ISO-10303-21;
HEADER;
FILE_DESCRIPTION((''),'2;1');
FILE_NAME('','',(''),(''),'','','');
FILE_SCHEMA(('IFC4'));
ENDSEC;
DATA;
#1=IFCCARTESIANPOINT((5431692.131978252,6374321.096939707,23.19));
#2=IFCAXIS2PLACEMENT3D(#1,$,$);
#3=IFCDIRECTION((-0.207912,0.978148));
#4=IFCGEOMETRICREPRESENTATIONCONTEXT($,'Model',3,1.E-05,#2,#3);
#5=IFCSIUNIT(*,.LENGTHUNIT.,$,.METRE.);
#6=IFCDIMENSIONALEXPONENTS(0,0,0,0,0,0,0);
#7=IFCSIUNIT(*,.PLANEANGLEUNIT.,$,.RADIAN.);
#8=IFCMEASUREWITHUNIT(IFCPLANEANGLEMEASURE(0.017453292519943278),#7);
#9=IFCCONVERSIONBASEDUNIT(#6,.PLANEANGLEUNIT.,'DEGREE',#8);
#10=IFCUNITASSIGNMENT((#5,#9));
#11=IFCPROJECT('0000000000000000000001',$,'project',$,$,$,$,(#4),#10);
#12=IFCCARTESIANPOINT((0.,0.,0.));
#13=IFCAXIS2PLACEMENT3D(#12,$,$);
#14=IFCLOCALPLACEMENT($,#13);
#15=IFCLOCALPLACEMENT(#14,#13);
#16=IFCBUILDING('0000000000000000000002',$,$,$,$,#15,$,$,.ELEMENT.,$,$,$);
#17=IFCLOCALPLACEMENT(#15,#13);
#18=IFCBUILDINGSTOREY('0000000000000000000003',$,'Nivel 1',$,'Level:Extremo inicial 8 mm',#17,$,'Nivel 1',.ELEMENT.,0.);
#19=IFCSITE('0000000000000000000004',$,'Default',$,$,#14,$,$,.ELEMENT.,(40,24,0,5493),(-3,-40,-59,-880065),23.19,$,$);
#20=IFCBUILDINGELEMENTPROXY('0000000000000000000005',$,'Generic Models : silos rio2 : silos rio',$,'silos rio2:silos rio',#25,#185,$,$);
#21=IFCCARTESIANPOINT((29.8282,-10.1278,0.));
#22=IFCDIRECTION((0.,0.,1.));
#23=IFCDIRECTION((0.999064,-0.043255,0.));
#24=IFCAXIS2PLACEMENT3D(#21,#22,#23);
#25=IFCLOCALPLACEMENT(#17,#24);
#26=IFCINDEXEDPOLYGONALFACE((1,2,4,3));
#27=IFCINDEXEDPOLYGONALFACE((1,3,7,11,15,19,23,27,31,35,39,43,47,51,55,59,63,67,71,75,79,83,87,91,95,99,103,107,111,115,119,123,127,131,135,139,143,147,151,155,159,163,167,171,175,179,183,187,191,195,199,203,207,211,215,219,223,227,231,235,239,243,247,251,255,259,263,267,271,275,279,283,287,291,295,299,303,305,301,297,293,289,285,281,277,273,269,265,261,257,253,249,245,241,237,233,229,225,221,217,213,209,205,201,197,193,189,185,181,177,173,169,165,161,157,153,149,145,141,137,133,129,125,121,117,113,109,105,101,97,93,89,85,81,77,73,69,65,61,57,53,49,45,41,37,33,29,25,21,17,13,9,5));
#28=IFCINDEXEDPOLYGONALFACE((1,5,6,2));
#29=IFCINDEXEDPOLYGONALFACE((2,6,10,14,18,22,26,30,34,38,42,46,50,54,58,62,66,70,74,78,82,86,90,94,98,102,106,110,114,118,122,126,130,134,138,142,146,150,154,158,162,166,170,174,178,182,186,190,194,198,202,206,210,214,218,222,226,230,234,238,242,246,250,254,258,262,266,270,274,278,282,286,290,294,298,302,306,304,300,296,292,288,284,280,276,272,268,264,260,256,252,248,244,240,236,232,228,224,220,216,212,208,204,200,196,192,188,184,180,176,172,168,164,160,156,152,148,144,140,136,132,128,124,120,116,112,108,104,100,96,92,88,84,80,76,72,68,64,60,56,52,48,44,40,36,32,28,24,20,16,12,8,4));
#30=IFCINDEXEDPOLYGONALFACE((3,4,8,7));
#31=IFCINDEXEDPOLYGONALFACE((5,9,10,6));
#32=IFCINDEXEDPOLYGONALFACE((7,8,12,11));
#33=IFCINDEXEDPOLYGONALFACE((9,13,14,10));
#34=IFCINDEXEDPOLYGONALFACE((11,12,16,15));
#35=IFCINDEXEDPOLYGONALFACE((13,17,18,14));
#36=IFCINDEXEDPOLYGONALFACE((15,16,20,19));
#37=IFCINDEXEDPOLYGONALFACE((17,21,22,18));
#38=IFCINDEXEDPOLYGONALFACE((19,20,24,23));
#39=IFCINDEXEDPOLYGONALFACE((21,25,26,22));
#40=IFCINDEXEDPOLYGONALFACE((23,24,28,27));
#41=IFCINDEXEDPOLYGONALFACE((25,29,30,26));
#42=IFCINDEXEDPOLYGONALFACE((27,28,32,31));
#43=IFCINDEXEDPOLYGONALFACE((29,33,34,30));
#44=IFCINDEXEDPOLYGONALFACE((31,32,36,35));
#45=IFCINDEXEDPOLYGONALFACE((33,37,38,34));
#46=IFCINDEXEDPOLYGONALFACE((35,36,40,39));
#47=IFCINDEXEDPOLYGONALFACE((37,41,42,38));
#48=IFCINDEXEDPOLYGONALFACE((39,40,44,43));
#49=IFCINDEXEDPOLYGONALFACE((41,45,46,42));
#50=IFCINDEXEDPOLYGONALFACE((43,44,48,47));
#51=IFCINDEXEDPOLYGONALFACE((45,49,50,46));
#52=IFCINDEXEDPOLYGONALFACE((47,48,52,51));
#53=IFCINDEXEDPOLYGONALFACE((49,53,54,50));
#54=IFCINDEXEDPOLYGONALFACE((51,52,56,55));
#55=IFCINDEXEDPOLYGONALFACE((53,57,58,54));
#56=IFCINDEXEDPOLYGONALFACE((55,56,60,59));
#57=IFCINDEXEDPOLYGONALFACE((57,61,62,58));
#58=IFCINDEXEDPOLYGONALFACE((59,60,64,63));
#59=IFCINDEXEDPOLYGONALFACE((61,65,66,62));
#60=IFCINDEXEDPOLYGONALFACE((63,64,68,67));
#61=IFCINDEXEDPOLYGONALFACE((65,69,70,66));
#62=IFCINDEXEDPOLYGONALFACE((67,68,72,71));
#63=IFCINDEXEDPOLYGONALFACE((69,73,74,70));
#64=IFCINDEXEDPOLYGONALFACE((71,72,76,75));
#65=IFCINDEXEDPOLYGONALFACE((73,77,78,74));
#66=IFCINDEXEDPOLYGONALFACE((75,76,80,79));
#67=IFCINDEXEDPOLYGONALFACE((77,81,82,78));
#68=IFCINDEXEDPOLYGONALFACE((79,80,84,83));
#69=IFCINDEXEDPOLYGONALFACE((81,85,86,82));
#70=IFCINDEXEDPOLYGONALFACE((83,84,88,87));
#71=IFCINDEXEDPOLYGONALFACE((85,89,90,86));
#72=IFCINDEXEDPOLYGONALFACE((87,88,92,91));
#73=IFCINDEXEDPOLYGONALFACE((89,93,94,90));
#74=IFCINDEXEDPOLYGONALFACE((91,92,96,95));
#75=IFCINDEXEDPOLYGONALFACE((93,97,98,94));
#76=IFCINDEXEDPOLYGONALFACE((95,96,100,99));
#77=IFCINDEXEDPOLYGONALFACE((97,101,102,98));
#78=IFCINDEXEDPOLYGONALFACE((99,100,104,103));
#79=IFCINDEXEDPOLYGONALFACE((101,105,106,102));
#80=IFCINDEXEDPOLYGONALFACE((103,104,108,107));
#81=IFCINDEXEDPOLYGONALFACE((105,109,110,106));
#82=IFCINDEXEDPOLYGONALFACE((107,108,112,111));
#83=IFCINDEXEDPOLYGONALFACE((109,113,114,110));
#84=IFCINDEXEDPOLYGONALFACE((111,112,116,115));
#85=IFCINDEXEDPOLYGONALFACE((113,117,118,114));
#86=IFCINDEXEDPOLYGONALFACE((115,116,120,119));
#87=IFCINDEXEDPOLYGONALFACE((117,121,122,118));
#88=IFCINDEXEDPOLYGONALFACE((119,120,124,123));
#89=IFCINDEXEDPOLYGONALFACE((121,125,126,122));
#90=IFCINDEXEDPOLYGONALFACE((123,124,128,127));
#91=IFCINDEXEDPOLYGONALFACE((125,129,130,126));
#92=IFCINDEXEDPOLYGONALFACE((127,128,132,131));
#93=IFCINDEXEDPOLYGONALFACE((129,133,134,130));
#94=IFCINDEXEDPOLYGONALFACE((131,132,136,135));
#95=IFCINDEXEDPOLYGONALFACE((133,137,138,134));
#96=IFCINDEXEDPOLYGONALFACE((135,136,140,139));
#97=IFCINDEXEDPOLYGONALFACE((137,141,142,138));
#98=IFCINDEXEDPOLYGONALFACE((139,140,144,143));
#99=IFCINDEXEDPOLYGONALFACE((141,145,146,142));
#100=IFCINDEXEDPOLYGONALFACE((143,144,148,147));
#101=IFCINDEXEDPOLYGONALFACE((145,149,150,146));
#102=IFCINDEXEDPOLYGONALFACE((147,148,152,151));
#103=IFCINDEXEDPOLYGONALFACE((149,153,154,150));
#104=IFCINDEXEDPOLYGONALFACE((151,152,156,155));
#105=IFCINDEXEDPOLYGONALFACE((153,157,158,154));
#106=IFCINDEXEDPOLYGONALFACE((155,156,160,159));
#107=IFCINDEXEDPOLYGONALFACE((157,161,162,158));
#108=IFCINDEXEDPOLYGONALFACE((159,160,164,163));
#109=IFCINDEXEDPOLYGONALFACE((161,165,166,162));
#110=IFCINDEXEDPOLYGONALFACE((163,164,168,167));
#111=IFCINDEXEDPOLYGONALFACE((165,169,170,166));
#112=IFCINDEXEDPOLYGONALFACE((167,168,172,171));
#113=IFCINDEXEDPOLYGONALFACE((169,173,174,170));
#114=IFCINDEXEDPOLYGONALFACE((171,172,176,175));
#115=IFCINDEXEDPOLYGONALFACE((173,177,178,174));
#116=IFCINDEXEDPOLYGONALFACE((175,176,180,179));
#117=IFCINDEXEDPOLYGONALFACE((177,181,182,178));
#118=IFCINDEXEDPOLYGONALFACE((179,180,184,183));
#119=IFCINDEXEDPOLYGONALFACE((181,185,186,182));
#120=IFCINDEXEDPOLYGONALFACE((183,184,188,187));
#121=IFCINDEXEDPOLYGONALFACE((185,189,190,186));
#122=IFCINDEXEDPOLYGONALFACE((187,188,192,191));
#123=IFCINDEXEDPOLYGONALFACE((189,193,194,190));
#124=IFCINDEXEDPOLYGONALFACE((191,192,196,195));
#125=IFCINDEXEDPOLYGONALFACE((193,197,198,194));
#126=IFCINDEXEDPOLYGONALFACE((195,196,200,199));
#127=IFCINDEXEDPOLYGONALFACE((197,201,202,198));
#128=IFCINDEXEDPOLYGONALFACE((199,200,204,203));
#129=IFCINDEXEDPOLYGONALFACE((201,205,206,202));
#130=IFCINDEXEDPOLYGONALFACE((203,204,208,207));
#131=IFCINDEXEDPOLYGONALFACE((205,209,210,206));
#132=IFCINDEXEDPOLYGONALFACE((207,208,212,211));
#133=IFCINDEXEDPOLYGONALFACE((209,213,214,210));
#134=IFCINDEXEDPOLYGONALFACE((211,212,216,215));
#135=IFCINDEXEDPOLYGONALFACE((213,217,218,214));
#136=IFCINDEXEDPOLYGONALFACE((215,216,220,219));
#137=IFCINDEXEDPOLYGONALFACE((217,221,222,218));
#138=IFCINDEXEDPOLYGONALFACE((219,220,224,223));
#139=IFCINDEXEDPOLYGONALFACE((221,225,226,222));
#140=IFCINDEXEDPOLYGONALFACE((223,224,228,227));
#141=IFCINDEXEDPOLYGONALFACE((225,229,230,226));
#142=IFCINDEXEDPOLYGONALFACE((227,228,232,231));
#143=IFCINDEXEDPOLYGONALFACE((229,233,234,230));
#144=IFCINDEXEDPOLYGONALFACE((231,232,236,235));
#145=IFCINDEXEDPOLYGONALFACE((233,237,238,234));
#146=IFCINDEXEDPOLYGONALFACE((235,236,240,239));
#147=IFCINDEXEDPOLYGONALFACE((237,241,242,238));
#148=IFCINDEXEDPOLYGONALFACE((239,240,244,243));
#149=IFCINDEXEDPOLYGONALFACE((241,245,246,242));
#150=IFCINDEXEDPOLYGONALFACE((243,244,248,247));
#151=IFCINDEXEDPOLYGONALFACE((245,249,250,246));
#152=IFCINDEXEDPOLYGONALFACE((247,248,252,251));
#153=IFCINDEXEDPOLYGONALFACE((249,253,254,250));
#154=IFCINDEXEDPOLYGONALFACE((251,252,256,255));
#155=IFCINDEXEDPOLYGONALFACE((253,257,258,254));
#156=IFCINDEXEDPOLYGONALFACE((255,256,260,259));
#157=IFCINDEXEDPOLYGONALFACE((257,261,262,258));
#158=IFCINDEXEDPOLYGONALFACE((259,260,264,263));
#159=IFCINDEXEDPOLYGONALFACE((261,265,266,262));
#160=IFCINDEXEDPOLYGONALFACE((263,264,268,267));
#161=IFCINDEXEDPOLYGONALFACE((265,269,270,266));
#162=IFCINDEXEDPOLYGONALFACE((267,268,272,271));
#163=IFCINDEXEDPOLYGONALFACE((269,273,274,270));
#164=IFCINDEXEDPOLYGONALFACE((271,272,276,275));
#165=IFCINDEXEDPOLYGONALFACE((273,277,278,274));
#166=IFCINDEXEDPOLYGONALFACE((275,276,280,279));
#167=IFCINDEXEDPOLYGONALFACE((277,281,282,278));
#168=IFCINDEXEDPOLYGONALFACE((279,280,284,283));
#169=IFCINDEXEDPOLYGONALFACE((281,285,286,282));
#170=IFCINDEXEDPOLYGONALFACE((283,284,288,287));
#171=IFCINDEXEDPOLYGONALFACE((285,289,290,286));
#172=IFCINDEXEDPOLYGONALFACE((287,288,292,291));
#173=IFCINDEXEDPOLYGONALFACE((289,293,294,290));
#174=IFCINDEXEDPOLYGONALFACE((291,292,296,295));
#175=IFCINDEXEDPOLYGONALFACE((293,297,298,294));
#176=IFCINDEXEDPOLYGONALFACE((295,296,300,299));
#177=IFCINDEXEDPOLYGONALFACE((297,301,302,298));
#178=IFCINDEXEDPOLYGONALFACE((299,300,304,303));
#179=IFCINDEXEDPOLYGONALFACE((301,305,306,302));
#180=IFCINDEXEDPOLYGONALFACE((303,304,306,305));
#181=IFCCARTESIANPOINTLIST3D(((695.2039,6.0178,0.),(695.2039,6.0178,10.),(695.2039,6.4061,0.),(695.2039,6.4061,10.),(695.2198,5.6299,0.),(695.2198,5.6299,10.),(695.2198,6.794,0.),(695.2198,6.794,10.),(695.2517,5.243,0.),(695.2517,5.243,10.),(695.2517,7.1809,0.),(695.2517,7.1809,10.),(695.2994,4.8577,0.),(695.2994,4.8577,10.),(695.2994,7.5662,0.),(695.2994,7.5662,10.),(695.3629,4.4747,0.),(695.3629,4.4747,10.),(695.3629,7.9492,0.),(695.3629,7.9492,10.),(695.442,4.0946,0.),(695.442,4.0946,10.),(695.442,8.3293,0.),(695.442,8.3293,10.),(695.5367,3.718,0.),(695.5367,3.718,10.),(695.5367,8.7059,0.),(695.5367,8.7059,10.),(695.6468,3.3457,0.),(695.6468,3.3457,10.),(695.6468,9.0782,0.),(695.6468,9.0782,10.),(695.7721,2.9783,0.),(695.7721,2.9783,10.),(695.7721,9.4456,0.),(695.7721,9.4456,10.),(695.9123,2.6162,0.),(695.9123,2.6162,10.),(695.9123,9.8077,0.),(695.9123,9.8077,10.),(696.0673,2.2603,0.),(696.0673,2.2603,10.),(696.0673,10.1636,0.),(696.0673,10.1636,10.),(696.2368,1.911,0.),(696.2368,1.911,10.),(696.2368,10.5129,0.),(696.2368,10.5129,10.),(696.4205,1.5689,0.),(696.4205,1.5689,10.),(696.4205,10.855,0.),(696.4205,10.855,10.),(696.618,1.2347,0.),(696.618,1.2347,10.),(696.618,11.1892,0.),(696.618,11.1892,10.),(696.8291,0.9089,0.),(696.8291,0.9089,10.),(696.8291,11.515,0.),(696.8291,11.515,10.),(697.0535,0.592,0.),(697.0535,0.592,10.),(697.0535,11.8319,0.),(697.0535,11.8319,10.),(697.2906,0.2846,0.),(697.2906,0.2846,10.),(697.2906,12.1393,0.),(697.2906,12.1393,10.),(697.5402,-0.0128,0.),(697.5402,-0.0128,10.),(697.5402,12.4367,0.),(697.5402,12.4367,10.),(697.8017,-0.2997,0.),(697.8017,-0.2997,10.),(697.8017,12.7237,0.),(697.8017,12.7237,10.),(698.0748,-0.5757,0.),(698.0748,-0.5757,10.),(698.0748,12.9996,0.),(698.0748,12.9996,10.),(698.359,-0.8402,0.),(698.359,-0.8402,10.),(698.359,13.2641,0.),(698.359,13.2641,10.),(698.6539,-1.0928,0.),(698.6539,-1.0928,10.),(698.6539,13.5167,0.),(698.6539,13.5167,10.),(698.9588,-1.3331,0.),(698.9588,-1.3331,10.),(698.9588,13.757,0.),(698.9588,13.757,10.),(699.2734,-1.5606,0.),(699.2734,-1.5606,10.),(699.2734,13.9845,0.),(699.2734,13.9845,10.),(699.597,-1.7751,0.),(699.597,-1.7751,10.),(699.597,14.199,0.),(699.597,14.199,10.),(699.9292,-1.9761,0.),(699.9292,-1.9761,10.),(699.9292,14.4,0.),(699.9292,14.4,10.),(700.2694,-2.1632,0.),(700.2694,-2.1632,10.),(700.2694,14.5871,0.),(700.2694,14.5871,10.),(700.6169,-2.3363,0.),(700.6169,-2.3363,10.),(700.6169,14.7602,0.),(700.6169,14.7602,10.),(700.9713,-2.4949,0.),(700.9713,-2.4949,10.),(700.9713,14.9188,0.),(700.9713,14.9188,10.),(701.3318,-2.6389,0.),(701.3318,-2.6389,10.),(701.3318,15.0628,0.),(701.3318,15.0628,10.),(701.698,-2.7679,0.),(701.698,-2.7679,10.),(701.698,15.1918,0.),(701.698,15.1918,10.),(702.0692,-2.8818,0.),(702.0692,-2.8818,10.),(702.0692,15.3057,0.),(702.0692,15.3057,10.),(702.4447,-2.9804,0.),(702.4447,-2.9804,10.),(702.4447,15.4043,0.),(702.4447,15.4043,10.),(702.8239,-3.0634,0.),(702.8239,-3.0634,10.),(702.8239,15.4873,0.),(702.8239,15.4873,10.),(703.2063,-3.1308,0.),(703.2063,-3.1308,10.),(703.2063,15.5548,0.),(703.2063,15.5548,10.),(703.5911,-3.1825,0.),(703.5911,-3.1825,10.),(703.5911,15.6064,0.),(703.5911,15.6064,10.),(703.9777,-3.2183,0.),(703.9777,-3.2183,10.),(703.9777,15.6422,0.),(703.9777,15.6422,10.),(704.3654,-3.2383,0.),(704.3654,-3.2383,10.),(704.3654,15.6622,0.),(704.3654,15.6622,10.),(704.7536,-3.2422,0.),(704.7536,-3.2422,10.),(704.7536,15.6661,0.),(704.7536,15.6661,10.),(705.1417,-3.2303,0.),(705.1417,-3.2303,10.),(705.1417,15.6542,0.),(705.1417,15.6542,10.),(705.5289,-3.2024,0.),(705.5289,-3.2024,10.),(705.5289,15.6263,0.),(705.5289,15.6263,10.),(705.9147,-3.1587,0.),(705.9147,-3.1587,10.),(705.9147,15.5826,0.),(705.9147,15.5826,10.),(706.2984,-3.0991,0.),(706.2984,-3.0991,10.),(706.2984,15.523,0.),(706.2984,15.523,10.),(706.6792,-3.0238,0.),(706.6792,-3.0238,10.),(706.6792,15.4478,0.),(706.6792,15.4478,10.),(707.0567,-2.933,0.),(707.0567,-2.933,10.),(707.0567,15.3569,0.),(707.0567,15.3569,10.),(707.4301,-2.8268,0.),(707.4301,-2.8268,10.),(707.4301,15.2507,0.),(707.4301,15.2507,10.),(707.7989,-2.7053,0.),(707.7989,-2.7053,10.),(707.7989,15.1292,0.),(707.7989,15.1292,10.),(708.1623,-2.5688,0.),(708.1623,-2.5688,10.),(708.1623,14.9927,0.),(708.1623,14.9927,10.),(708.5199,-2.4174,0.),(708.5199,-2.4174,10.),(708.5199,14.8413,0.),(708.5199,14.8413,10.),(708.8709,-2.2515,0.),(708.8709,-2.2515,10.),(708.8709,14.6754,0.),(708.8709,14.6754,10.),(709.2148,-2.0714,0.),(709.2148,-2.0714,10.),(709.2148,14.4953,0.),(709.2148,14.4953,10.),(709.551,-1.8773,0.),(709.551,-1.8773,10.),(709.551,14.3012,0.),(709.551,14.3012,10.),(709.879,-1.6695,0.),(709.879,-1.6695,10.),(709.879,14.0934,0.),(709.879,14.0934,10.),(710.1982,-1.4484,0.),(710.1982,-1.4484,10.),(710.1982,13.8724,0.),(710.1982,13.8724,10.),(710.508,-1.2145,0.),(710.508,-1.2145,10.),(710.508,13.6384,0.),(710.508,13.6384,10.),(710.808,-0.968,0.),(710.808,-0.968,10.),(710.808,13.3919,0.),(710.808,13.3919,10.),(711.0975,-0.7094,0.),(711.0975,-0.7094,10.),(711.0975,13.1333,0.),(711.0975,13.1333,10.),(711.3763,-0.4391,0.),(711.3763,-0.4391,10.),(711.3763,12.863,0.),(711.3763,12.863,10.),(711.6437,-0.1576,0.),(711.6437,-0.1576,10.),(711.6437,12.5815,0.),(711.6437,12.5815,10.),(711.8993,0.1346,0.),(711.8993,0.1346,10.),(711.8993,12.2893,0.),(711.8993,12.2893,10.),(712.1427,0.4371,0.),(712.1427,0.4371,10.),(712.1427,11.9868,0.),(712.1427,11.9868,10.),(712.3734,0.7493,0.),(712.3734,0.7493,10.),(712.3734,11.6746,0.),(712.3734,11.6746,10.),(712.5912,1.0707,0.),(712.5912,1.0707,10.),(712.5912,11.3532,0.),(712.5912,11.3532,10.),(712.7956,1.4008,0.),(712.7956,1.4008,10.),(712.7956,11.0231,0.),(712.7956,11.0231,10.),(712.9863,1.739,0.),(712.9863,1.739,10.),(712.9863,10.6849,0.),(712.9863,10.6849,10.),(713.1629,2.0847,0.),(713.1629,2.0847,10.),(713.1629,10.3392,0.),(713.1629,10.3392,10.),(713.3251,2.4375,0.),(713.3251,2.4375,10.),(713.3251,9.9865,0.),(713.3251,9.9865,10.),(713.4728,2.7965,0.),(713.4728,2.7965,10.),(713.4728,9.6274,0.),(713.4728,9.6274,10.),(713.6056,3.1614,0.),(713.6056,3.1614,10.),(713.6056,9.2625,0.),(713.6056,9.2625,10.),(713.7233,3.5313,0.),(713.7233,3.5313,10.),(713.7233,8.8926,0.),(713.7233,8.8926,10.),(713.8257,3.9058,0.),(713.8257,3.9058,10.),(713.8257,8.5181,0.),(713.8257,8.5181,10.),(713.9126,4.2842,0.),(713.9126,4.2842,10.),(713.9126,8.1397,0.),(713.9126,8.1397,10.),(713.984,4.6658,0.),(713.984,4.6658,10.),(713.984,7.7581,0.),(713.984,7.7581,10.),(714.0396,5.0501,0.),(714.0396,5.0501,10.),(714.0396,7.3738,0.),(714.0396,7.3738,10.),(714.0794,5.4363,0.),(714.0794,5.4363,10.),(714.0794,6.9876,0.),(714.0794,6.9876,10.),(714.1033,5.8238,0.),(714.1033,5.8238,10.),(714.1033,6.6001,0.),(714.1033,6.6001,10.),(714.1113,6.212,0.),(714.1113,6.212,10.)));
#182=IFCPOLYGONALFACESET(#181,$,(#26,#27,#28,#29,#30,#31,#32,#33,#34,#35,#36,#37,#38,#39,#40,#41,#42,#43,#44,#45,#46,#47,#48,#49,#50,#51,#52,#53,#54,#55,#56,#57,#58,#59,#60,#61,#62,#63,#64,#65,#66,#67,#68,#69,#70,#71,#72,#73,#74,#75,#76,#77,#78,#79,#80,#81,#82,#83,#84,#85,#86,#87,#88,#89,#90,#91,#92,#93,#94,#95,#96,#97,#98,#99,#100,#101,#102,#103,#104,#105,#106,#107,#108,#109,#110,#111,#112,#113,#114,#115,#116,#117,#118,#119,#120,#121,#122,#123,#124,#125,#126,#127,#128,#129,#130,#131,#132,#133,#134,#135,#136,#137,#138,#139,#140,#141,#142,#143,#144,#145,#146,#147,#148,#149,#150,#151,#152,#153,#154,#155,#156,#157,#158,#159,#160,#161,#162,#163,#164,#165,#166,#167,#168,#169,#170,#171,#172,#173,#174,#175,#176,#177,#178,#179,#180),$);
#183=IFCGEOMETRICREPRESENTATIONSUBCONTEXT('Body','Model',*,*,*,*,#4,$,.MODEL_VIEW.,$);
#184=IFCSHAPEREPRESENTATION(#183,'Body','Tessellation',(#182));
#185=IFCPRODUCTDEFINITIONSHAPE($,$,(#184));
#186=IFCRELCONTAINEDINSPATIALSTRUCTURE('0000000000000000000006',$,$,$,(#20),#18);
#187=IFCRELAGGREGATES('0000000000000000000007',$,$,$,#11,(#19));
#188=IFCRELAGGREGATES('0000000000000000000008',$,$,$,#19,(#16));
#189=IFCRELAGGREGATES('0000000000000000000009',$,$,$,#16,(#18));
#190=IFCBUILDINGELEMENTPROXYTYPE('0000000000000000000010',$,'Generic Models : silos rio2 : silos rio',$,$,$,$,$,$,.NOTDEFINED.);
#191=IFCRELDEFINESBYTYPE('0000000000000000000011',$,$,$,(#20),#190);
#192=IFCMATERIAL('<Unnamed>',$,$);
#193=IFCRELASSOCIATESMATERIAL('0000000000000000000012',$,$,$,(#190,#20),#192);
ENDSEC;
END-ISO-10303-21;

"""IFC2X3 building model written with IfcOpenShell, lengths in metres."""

from ifc_helpers import new_model, entity, si_unit, converted_unit, direction, frame, frame_2d, origin, place, context, subcontext, project, spatial, circle, extrude, source, transform, mapped, material, type_object, type_shapes, element, save


model = new_model("IFC2X3")

# Units and contexts
model_context = context("Model", 3, precision=1e-05, world=frame((5431692.131978252, 6374321.096939707, 23.19)), true_north=direction((-0.207912, 0.978148)))
body_context = subcontext(model_context, "Body", "Model", "MODEL_VIEW")
ifc_project = project(units=[si_unit("LENGTHUNIT", "METRE"), converted_unit("PLANEANGLEUNIT", "DEGREE", entity("IfcPlaneAngleMeasure", 0.017453292519943278), si_unit("PLANEANGLEUNIT", "RADIAN"), dimensions=[0, 0, 0, 0, 0, 0, 0])], contexts=[model_context])

# Site, building, storey
site_placement = place(None, origin())
site = spatial("IfcSite", under=ifc_project, at=site_placement, Name="Default", CompositionType="ELEMENT", RefLatitude=(40, 24, 0, 5493), RefLongitude=(-3, -40, -59, -880065), RefElevation=23.19)
building_placement = place(site_placement, origin())
building = spatial("IfcBuilding", under=site, at=building_placement, CompositionType="ELEMENT")
storey_placement = place(building_placement, origin())
storey = spatial("IfcBuildingStorey", under=building, at=storey_placement, Name="Nivel 1", ObjectType="Level:Extremo inicial 8 mm", LongName="Nivel 1", CompositionType="ELEMENT", Elevation=0.0)

# Building element proxy
ifc_material_1 = material(Name="<Unnamed>")
building_element_proxy_type_1 = type_object("IfcBuildingElementProxyType", Name="Generic Models : silos rio2 : silos rio", PredefinedType="NOTDEFINED", material=ifc_material_1)
shared_shape_1 = source(origin(), body_context, "Body", "SweptSolid", [
    extrude(circle(Radius=9.4547, at=frame_2d((0.0, 0.0), x_axis=(1.0, 0.0))), frame((704.6566, 6.212, 0.0)), (0.0, 0.0, 1.0), 10.0),
])
type_shapes(building_element_proxy_type_1, [shared_shape_1])
proxy_1_placement = place(storey_placement, frame((29.8282, -10.1278, 0.0), z_axis=(0.0, 0.0, 1.0), x_axis=(0.999064, -0.043255, 0.0)))
element("IfcBuildingElementProxy", 1, at=proxy_1_placement, inside=storey, type_object=building_element_proxy_type_1, material=ifc_material_1, Name="Generic Models : silos rio2 : silos rio", ObjectType="silos rio2:silos rio", context=body_context, shape_type="MappedRepresentation", body=[
    mapped(shared_shape_1, transform((0.0, 0.0, 0.0), scale=1.0)),
])

save(model, "model.ifc")
